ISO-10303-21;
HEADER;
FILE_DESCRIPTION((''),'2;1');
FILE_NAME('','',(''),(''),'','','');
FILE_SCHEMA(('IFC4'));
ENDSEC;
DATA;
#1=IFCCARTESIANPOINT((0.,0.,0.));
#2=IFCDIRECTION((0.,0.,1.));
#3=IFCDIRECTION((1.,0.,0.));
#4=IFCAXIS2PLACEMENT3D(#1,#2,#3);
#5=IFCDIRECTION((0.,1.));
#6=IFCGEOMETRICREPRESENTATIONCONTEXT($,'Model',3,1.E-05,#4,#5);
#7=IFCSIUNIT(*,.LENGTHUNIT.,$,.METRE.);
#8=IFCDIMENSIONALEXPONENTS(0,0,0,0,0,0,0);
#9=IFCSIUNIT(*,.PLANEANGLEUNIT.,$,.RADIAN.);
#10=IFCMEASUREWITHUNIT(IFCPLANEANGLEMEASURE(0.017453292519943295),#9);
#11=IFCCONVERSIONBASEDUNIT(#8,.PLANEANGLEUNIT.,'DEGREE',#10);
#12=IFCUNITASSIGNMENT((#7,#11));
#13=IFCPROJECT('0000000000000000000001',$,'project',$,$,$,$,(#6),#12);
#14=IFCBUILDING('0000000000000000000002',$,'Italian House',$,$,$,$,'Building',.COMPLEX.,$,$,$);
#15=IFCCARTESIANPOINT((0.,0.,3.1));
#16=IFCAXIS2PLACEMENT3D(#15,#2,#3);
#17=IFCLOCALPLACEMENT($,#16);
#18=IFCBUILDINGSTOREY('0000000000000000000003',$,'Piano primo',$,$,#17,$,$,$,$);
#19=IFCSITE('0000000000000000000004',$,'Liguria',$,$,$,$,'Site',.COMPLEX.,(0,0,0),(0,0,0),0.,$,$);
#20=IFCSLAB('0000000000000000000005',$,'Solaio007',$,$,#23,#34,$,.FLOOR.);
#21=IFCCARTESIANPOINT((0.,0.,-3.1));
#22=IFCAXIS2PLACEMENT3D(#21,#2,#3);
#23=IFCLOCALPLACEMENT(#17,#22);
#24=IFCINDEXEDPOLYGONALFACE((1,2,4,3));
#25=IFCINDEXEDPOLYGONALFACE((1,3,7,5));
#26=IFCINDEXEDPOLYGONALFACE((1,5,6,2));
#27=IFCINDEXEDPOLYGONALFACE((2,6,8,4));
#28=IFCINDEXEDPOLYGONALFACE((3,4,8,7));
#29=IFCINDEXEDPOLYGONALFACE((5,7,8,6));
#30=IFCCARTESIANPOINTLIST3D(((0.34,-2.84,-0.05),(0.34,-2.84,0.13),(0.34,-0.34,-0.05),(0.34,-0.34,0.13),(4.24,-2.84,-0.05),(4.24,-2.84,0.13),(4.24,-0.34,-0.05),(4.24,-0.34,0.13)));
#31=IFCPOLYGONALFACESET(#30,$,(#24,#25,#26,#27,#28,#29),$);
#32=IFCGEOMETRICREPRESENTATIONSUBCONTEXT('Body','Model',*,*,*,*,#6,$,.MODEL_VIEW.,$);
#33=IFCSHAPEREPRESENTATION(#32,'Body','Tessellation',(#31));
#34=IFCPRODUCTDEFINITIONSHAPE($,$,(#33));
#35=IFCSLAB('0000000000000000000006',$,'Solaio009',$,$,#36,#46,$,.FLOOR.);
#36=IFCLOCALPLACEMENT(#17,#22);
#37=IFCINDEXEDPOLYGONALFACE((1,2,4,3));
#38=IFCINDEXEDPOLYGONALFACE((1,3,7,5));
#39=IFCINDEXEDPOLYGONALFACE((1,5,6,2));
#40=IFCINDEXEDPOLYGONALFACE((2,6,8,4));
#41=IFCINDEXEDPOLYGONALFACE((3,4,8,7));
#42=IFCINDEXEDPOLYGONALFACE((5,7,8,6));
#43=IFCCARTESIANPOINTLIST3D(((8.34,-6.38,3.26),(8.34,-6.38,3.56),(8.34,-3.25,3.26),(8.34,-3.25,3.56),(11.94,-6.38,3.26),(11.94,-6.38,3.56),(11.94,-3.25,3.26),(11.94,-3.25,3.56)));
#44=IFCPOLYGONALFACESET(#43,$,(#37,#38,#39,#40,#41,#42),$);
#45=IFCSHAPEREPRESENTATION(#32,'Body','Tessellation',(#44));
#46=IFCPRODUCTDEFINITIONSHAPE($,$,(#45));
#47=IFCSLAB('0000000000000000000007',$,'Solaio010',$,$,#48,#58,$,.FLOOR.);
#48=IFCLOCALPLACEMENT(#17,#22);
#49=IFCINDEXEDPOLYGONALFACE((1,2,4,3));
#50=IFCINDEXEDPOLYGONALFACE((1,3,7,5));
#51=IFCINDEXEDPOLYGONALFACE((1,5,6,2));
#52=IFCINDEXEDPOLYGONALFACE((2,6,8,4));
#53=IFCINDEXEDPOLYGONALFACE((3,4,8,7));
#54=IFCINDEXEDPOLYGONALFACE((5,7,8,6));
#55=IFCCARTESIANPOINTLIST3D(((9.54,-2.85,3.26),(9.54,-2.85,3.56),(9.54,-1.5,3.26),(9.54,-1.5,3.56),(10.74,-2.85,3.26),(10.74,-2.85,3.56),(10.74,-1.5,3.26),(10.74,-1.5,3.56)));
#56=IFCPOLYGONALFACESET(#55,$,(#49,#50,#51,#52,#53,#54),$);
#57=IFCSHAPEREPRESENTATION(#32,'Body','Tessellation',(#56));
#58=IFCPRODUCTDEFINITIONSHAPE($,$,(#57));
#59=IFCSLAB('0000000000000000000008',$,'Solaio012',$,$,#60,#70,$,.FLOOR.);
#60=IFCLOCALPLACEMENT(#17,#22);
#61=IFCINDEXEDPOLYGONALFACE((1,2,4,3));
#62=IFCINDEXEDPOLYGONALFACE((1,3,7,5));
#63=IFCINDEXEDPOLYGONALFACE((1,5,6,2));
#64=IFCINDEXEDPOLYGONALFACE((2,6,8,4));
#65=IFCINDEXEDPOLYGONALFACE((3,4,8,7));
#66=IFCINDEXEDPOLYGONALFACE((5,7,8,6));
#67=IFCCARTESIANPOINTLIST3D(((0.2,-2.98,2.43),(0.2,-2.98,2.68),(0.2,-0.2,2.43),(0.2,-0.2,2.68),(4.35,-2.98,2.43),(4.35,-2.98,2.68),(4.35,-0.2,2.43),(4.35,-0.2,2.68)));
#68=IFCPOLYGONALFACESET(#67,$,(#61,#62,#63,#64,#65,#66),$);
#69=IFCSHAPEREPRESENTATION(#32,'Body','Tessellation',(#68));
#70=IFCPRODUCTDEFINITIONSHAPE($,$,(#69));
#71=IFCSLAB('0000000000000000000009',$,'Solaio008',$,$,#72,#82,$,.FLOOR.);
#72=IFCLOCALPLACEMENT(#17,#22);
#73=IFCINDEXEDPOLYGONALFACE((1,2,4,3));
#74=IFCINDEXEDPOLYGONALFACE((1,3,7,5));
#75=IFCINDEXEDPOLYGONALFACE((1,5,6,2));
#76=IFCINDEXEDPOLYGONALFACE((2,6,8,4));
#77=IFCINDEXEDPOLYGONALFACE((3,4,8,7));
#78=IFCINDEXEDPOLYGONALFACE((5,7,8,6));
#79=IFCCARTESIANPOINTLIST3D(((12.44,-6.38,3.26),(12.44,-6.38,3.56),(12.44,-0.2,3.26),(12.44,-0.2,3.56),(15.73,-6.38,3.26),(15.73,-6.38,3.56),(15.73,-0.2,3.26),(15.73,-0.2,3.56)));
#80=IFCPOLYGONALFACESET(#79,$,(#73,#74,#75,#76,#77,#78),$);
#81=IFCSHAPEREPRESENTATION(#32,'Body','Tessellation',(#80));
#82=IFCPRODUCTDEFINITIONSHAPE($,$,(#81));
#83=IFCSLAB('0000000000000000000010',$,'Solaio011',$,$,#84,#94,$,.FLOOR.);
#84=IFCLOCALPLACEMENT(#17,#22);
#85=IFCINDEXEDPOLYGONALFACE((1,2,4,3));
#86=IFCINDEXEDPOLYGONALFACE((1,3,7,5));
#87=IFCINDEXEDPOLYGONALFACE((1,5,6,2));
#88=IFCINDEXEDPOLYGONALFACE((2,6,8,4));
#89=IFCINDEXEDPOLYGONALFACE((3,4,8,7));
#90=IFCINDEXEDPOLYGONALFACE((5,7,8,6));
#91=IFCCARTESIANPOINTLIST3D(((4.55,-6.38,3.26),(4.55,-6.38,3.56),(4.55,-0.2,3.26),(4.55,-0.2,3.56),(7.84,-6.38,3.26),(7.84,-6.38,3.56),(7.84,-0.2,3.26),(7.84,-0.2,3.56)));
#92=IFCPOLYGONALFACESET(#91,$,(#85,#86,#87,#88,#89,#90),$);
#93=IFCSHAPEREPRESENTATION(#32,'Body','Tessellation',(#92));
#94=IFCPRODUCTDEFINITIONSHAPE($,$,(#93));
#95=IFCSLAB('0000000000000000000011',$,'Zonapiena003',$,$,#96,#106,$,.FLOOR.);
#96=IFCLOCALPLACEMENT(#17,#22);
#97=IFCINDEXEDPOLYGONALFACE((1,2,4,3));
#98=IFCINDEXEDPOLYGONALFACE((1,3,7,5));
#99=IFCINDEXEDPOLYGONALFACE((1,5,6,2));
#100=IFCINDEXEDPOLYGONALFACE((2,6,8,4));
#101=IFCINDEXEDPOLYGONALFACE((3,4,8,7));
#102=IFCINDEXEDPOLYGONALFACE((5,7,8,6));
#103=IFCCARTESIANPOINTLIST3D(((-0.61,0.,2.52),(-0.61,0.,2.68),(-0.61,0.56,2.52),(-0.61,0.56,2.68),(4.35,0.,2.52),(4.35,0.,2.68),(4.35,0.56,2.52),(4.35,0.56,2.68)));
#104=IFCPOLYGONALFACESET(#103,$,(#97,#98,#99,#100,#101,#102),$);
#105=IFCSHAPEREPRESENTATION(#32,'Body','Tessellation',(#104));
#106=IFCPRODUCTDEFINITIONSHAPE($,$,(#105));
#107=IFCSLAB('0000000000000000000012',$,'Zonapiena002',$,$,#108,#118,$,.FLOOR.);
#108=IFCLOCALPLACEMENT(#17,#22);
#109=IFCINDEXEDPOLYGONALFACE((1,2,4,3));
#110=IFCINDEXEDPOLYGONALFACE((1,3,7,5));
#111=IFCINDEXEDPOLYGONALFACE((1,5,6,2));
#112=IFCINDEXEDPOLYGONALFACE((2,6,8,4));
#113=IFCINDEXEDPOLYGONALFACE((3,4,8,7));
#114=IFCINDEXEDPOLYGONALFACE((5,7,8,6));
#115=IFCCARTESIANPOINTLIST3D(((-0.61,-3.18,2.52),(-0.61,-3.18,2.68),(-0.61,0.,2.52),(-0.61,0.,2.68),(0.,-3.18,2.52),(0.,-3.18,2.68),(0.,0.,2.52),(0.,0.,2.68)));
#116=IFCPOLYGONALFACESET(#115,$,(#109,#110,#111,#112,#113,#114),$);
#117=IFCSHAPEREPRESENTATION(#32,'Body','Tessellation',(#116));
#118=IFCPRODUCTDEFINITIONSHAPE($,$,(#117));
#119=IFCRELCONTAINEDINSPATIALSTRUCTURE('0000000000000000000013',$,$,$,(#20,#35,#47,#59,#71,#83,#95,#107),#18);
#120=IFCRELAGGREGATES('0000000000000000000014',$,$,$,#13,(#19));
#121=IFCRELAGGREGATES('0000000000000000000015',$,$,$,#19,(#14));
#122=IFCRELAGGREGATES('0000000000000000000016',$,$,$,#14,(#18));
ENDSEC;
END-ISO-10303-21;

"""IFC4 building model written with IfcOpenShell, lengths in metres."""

from ifc_helpers import new_model, entity, si_unit, converted_unit, direction, frame, frame_2d, origin_with_axes, origin_2d_with_axis, place, context, subcontext, project, spatial, rectangle, extrude, element, save


model = new_model("IFC4")

# Units and contexts
model_context = context("Model", 3, precision=1e-05, world=origin_with_axes(), true_north=direction((0.0, 1.0)))
body_context = subcontext(model_context, "Body", "Model", "MODEL_VIEW")
ifc_project = project(units=[si_unit("LENGTHUNIT", "METRE"), converted_unit("PLANEANGLEUNIT", "DEGREE", entity("IfcPlaneAngleMeasure", 0.017453292519943295), si_unit("PLANEANGLEUNIT", "RADIAN"), dimensions=[0, 0, 0, 0, 0, 0, 0])], contexts=[model_context])

# Site, building, storey
site = spatial("IfcSite", under=ifc_project, Name="Liguria", LongName="Site", CompositionType="COMPLEX", RefLatitude=(0, 0, 0), RefLongitude=(0, 0, 0), RefElevation=0.0)
building = spatial("IfcBuilding", under=site, Name="Italian House", LongName="Building", CompositionType="COMPLEX")
storey_placement = place(None, frame((0.0, 0.0, 3.1), z_axis=(0.0, 0.0, 1.0), x_axis=(1.0, 0.0, 0.0)))
storey = spatial("IfcBuildingStorey", under=building, at=storey_placement, Name="Piano primo")

# Slabs
slab_1_placement = place(storey_placement, frame((0.0, 0.0, -3.1), z_axis=(0.0, 0.0, 1.0), x_axis=(1.0, 0.0, 0.0)))
element("IfcSlab", 1, at=slab_1_placement, inside=storey, Name="Solaio007", PredefinedType="FLOOR", context=body_context, shape_type="SweptSolid", body=[
    extrude(rectangle(XDim=3.9, YDim=2.5, at=origin_2d_with_axis()), frame((2.29, -1.59, 0.13), z_axis=(0.0, 0.0, 1.0), x_axis=(1.0, 0.0, 0.0)), (0.0, 0.0, -1.0), 0.18),
])
slab_2_placement = place(storey_placement, frame((0.0, 0.0, -3.1), z_axis=(0.0, 0.0, 1.0), x_axis=(1.0, 0.0, 0.0)))
element("IfcSlab", 2, at=slab_2_placement, inside=storey, Name="Solaio009", PredefinedType="FLOOR", context=body_context, shape_type="SweptSolid", body=[
    extrude(rectangle(XDim=3.6, YDim=3.13, at=frame_2d((0.0, 0.0), x_axis=(1.0, 0.0))), frame((10.14, -4.815, 3.56), z_axis=(0.0, 0.0, 1.0), x_axis=(1.0, 0.0, 0.0)), (0.0, 0.0, -1.0), 0.3),
])
slab_3_placement = place(storey_placement, frame((0.0, 0.0, -3.1), z_axis=(0.0, 0.0, 1.0), x_axis=(1.0, 0.0, 0.0)))
element("IfcSlab", 3, at=slab_3_placement, inside=storey, Name="Solaio010", PredefinedType="FLOOR", context=body_context, shape_type="SweptSolid", body=[
    extrude(rectangle(XDim=1.2, YDim=1.35, at=frame_2d((0.0, 0.0), x_axis=(1.0, 0.0))), frame((10.14, -2.175, 3.56), z_axis=(0.0, 0.0, 1.0), x_axis=(1.0, 0.0, 0.0)), (0.0, 0.0, -1.0), 0.3),
])
slab_4_placement = place(storey_placement, frame((0.0, 0.0, -3.1), z_axis=(0.0, 0.0, 1.0), x_axis=(1.0, 0.0, 0.0)))
element("IfcSlab", 4, at=slab_4_placement, inside=storey, Name="Solaio012", PredefinedType="FLOOR", context=body_context, shape_type="SweptSolid", body=[
    extrude(rectangle(XDim=4.15, YDim=2.78, at=origin_2d_with_axis()), frame((2.275, -1.59, 2.68), z_axis=(0.0, 0.0, 1.0), x_axis=(1.0, 0.0, 0.0)), (0.0, 0.0, -1.0), 0.25),
])
slab_5_placement = place(storey_placement, frame((0.0, 0.0, -3.1), z_axis=(0.0, 0.0, 1.0), x_axis=(1.0, 0.0, 0.0)))
element("IfcSlab", 5, at=slab_5_placement, inside=storey, Name="Solaio008", PredefinedType="FLOOR", context=body_context, shape_type="SweptSolid", body=[
    extrude(rectangle(XDim=3.29, YDim=6.18, at=origin_2d_with_axis()), frame((14.085, -3.29, 3.56), z_axis=(0.0, 0.0, 1.0), x_axis=(1.0, 0.0, 0.0)), (0.0, 0.0, -1.0), 0.3),
])
slab_6_placement = place(storey_placement, frame((0.0, 0.0, -3.1), z_axis=(0.0, 0.0, 1.0), x_axis=(1.0, 0.0, 0.0)))
element("IfcSlab", 6, at=slab_6_placement, inside=storey, Name="Solaio011", PredefinedType="FLOOR", context=body_context, shape_type="SweptSolid", body=[
    extrude(rectangle(XDim=3.29, YDim=6.18, at=frame_2d((0.0, 0.0), x_axis=(1.0, 0.0))), frame((6.195, -3.29, 3.56), z_axis=(0.0, 0.0, 1.0), x_axis=(1.0, 0.0, 0.0)), (0.0, 0.0, -1.0), 0.3),
])
slab_7_placement = place(storey_placement, frame((0.0, 0.0, -3.1), z_axis=(0.0, 0.0, 1.0), x_axis=(1.0, 0.0, 0.0)))
element("IfcSlab", 7, at=slab_7_placement, inside=storey, Name="Zonapiena003", PredefinedType="FLOOR", context=body_context, shape_type="SweptSolid", body=[
    extrude(rectangle(XDim=4.96, YDim=0.56, at=origin_2d_with_axis()), frame((1.87, 0.28, 2.68), z_axis=(0.0, 0.0, 1.0), x_axis=(1.0, 0.0, 0.0)), (0.0, 0.0, -1.0), 0.16),
])
slab_8_placement = place(storey_placement, frame((0.0, 0.0, -3.1), z_axis=(0.0, 0.0, 1.0), x_axis=(1.0, 0.0, 0.0)))
element("IfcSlab", 8, at=slab_8_placement, inside=storey, Name="Zonapiena002", PredefinedType="FLOOR", context=body_context, shape_type="SweptSolid", body=[
    extrude(rectangle(XDim=0.61, YDim=3.18, at=frame_2d((0.0, 0.0), x_axis=(-1.0, 0.0))), frame((-0.305, -1.59, 2.68), z_axis=(0.0, 0.0, 1.0), x_axis=(1.0, 0.0, 0.0)), (0.0, 0.0, -1.0), 0.16),
])

save(model, "model.ifc")
